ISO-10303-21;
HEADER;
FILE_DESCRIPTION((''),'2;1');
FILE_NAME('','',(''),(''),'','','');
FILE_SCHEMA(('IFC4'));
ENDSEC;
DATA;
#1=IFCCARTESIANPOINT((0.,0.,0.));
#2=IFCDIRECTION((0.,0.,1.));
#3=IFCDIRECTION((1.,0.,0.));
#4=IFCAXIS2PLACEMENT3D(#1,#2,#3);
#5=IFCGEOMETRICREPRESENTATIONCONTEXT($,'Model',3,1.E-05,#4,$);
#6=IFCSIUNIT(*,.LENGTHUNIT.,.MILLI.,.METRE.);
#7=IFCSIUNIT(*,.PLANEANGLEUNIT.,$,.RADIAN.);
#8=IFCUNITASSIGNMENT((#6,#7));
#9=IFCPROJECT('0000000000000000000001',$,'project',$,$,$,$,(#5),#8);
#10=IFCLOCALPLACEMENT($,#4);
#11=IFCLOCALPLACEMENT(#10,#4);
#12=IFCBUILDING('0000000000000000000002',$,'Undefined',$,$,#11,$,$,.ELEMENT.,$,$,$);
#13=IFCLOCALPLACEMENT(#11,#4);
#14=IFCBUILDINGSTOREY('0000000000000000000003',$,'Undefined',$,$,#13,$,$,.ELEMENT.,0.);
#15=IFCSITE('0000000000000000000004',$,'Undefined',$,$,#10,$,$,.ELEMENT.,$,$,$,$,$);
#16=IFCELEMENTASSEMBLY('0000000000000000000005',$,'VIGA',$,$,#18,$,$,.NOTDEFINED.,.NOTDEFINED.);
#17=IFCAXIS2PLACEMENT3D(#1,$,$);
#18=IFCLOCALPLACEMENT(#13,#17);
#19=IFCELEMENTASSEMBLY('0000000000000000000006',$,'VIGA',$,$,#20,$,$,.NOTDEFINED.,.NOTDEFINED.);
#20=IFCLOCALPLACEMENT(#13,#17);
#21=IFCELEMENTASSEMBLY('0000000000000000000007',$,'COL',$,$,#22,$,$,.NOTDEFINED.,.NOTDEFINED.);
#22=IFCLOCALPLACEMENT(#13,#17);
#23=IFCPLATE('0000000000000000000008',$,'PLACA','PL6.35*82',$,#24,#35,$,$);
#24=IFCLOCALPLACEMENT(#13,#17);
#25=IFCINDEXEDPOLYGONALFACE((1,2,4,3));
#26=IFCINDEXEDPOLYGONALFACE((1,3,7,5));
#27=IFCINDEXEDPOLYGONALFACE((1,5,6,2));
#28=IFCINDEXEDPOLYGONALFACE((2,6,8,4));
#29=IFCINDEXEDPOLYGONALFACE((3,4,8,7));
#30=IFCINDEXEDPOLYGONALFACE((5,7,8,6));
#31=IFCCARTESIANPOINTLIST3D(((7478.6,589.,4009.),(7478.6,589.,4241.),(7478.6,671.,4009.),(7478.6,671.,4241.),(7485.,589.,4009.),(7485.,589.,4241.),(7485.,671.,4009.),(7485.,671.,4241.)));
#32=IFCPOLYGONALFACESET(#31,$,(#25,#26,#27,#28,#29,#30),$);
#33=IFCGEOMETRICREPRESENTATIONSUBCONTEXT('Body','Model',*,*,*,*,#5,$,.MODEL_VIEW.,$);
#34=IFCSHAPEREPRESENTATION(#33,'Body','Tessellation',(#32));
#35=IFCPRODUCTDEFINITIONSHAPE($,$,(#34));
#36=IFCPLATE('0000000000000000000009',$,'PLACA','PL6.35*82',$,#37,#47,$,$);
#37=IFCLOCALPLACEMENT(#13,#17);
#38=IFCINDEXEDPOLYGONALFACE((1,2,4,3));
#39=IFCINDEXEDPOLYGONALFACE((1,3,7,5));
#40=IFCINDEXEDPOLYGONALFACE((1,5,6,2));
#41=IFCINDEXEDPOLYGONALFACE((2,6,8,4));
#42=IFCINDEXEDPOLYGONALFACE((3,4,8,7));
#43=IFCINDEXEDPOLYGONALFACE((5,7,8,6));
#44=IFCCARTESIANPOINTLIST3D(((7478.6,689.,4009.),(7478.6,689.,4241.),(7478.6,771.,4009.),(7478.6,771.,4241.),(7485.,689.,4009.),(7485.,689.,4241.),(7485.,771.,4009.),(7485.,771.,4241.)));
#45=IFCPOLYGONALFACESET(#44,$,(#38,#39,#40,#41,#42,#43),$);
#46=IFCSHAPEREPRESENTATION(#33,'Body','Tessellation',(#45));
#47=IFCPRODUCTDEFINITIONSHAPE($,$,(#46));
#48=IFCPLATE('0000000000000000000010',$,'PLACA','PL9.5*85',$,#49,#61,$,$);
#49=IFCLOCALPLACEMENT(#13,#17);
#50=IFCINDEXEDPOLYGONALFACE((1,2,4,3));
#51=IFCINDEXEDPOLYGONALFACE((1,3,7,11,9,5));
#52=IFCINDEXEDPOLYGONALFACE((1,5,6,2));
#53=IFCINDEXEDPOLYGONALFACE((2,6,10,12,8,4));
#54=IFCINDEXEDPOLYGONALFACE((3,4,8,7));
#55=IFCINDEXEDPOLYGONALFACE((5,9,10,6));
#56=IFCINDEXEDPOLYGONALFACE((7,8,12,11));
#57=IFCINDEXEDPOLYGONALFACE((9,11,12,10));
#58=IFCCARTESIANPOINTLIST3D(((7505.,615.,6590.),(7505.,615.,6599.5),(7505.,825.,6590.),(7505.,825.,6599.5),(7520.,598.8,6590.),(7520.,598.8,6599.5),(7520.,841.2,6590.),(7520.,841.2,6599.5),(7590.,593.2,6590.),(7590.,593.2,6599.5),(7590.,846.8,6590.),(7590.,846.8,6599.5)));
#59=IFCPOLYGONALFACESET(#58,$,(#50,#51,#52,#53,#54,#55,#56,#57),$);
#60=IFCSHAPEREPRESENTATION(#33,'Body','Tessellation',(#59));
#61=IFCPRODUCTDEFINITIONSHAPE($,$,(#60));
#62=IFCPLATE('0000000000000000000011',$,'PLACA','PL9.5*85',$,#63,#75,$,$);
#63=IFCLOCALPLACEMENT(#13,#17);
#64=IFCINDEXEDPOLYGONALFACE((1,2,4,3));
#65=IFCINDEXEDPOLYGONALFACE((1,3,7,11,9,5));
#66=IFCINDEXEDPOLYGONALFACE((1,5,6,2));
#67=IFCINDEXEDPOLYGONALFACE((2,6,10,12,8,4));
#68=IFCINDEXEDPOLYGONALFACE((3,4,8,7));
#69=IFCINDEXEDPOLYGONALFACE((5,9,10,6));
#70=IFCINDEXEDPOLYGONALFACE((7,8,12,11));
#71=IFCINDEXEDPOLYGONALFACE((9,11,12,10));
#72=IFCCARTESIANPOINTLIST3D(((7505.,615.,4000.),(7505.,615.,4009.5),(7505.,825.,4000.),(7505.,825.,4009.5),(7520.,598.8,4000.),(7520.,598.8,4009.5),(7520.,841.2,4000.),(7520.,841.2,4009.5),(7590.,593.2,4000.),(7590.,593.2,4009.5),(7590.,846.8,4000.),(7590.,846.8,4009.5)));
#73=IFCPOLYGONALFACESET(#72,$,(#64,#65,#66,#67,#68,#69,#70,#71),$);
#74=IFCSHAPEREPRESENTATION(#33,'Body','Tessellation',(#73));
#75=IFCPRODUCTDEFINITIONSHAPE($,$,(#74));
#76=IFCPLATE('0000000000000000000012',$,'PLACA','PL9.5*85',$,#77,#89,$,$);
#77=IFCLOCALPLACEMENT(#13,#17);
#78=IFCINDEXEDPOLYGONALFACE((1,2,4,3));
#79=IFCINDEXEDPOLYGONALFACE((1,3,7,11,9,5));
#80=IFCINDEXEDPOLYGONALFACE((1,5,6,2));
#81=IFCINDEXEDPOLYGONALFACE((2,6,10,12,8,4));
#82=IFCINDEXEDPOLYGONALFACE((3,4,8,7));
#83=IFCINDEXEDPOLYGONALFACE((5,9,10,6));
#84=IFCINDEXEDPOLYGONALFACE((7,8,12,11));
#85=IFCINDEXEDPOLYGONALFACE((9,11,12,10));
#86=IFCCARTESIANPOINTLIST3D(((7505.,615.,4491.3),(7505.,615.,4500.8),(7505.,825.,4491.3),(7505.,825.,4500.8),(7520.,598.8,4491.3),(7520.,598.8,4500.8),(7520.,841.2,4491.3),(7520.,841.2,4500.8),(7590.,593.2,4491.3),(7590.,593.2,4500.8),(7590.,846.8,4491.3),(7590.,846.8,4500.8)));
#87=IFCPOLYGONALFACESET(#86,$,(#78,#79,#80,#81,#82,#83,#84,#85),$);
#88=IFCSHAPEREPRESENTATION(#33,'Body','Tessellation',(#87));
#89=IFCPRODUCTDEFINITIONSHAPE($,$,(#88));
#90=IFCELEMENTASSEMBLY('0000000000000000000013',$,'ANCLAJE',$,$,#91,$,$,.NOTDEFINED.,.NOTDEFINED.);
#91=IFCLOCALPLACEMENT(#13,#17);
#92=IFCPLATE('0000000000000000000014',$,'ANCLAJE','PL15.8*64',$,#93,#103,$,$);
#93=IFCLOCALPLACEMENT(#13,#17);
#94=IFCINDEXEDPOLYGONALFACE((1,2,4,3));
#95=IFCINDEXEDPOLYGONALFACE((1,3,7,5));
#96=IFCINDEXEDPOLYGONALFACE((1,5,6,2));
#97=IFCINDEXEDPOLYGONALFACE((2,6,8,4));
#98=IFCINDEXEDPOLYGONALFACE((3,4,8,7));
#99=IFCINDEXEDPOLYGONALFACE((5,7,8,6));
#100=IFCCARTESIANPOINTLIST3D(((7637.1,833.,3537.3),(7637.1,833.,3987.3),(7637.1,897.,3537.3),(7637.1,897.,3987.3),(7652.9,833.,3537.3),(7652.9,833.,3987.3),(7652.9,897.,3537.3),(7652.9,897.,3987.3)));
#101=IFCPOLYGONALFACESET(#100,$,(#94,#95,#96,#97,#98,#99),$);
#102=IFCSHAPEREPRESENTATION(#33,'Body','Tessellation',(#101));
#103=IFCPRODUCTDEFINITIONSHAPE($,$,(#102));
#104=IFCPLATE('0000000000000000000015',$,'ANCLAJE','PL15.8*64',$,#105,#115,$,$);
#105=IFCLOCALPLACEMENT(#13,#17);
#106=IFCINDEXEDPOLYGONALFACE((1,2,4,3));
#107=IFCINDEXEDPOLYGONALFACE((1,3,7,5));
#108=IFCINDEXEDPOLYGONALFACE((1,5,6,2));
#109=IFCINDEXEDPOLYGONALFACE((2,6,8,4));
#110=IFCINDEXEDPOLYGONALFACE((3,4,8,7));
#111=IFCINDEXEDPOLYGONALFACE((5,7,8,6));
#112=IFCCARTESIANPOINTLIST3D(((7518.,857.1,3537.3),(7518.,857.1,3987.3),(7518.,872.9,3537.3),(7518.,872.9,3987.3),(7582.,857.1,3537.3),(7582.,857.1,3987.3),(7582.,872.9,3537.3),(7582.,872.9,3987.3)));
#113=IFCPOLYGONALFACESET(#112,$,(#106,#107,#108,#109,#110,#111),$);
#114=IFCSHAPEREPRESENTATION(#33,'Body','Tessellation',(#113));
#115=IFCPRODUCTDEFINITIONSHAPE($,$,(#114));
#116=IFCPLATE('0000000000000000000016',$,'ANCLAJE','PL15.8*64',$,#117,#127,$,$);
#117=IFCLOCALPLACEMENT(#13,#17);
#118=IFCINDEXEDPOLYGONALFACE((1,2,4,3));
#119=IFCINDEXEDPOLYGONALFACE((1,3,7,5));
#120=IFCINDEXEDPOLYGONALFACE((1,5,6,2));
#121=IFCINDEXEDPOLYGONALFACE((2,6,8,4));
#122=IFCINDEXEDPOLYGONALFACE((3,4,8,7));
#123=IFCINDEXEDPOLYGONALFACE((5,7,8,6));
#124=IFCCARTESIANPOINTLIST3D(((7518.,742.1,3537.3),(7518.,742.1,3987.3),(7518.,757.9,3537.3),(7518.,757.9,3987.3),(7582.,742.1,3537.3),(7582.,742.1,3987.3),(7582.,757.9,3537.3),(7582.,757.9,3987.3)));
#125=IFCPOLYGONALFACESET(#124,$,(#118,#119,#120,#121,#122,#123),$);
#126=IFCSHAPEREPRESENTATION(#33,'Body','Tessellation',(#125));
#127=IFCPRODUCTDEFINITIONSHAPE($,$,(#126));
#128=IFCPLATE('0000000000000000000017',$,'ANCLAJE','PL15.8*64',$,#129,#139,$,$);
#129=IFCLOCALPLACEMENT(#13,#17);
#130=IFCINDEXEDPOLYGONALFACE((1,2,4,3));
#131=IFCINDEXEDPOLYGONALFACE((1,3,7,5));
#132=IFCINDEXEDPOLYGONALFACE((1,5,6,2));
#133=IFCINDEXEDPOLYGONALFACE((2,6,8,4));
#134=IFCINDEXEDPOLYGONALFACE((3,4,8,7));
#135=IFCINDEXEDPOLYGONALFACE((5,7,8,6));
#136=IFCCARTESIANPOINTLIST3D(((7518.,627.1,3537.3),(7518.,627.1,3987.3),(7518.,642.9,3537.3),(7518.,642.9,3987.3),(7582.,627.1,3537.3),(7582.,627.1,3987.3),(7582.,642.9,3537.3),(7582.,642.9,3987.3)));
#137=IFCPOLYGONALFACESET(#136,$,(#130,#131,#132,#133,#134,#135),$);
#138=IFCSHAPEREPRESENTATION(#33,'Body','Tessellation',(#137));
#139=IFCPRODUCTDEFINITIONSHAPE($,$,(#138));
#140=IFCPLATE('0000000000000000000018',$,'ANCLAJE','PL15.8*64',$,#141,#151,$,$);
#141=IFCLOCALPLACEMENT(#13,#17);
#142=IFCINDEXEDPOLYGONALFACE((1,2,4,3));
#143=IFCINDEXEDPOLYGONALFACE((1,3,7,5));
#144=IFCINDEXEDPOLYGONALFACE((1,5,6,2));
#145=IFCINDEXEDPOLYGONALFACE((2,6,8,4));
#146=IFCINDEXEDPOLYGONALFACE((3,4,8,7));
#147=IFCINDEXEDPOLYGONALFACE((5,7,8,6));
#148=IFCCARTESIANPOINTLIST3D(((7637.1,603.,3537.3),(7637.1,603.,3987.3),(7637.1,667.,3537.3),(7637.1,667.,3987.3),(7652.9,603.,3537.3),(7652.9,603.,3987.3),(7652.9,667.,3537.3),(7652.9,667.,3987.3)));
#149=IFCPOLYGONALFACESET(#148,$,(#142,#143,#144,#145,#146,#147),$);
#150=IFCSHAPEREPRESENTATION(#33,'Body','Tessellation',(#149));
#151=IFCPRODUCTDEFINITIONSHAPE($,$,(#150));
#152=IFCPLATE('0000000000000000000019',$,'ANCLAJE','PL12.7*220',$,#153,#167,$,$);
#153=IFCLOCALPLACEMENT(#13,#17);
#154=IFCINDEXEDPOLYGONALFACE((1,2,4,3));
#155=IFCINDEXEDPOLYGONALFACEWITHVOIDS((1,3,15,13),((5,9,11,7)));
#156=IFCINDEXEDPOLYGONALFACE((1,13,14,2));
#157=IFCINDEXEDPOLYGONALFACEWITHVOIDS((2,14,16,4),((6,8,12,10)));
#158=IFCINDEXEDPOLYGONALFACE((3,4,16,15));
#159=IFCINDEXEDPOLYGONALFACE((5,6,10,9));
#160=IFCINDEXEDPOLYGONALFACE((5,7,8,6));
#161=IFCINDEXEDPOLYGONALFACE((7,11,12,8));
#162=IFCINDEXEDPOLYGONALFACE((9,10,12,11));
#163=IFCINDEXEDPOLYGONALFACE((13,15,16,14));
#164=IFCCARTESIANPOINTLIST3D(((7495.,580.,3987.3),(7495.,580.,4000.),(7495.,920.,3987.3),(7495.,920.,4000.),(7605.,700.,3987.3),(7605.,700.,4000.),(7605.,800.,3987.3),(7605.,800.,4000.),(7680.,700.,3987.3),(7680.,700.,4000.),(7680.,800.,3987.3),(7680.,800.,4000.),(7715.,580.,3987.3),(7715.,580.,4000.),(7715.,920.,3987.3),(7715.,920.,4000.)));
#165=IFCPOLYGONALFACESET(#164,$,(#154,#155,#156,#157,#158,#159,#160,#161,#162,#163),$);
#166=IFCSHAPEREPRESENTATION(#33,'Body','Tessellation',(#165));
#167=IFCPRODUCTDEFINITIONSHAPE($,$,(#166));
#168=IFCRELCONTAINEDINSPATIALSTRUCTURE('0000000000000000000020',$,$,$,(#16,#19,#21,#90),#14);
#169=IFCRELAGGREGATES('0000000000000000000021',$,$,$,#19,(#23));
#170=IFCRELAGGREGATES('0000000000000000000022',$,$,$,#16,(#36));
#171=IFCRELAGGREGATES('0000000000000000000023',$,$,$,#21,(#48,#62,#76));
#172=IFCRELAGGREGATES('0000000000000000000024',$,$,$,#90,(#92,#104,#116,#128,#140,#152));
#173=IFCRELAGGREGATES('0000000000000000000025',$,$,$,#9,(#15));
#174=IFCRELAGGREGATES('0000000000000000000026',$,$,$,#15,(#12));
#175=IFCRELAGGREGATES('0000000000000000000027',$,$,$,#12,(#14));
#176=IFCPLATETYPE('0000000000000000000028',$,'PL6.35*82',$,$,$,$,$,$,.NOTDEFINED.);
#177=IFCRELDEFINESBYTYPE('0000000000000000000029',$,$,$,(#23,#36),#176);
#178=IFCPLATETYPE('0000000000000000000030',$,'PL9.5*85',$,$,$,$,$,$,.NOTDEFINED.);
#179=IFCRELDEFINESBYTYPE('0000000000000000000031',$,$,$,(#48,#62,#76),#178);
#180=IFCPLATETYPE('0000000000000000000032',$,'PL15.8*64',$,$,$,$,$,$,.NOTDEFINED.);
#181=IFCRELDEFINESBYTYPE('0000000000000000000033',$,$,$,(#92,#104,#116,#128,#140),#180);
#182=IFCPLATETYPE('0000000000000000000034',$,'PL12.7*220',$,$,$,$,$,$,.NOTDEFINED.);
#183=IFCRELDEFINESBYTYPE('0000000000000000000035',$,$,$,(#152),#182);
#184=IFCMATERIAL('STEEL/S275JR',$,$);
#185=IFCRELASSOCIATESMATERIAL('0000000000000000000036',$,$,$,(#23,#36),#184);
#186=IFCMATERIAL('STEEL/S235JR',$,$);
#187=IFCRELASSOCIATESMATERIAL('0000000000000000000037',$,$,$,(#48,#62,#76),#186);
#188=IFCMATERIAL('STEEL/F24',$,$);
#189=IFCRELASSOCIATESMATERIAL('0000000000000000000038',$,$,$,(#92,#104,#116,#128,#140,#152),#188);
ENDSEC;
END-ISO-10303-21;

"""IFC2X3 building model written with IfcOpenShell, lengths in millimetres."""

from ifc_helpers import new_model, si_unit, frame, origin_with_axes, place, context, subcontext, project, spatial, polyline, outline, extrude, boolean, material, type_object, element, aggregate, save


model = new_model("IFC2X3")

# Units and contexts
model_context = context("Model", 3, precision=1e-05, world=origin_with_axes())
body_context = subcontext(model_context, "Body", "Model", "MODEL_VIEW")
ifc_project = project(units=[si_unit("LENGTHUNIT", "METRE", prefix="MILLI"), si_unit("PLANEANGLEUNIT", "RADIAN")], contexts=[model_context])

# Site, building, storey
site_placement = place(None, origin_with_axes())
site = spatial("IfcSite", under=ifc_project, at=site_placement, Name="Undefined", CompositionType="ELEMENT")
building_placement = place(site_placement, origin_with_axes())
building = spatial("IfcBuilding", under=site, at=building_placement, Name="Undefined", CompositionType="ELEMENT")
storey_placement = place(building_placement, origin_with_axes())
storey = spatial("IfcBuildingStorey", under=building, at=storey_placement, Name="Undefined", CompositionType="ELEMENT", Elevation=0.0)

# Shared definitions
ifc_material_1 = material(Name="STEEL/S275JR")

# Element assemblies
ifc_material_2 = material(Name="STEEL/S235JR")
assembly_1_placement = place(storey_placement, origin_with_axes())
assembly_1 = element("IfcElementAssembly", 1, at=assembly_1_placement, inside=storey, Name="VIGA", AssemblyPlace="NOTDEFINED", PredefinedType="NOTDEFINED")
assembly_2_placement = place(storey_placement, origin_with_axes())
assembly_2 = element("IfcElementAssembly", 2, at=assembly_2_placement, inside=storey, Name="VIGA", AssemblyPlace="NOTDEFINED", PredefinedType="NOTDEFINED")

# Element assembly
assembly_3_placement = place(storey_placement, origin_with_axes())
assembly_3 = element("IfcElementAssembly", 3, at=assembly_3_placement, inside=storey, Name="COL", AssemblyPlace="NOTDEFINED", PredefinedType="NOTDEFINED")

# Plates
plate_type_1 = type_object("IfcPlateType", Name="PL6.35*82", PredefinedType="NOTDEFINED")
plate_1_placement = place(assembly_2_placement, frame((7481.8, 589.0, 4241.0), z_axis=(-1.0, 0.0, 0.0), x_axis=(0.0, 1.0, 0.0)))
plate_1 = element("IfcPlate", 4, at=plate_1_placement, type_object=plate_type_1, material=ifc_material_1, Name="PLACA", Description="PL6.35*82", context=body_context, shape_type="SweptSolid", body=[
    extrude(outline(polyline([(0.0, 0.0), (82.0, 0.0), (82.0, 232.0), (0.0, 232.0), (0.0, 0.0)])), frame((0.0, 0.0, -3.2), z_axis=(0.0, 0.0, 1.0), x_axis=(1.0, 0.0, 0.0)), (0.0, 0.0, 1.0), 6.4),
])
aggregate(assembly_2, [plate_1])
plate_2_placement = place(assembly_1_placement, frame((7481.8, 689.0, 4241.0), z_axis=(-1.0, 0.0, 0.0), x_axis=(0.0, 1.0, 0.0)))
plate_2 = element("IfcPlate", 5, at=plate_2_placement, type_object=plate_type_1, material=ifc_material_1, Name="PLACA", Description="PL6.35*82", context=body_context, shape_type="SweptSolid", body=[
    extrude(outline(polyline([(0.0, 0.0), (82.0, 0.0), (82.0, 232.0), (0.0, 232.0), (0.0, 0.0)])), frame((0.0, 0.0, -3.2), z_axis=(0.0, 0.0, 1.0), x_axis=(1.0, 0.0, 0.0)), (0.0, 0.0, 1.0), 6.4),
])
aggregate(assembly_1, [plate_2])
plate_type_2 = type_object("IfcPlateType", Name="PL9.5*85", PredefinedType="NOTDEFINED")
plate_3_placement = place(assembly_3_placement, frame((7590.0, 846.8, 6594.8), z_axis=(0.0, 0.0, 1.0), x_axis=(-0.996815, -0.079745, 0.0)))
plate_3 = element("IfcPlate", 6, at=plate_3_placement, type_object=plate_type_2, material=ifc_material_2, Name="PLACA", Description="PL9.5*85", context=body_context, shape_type="SweptSolid", body=[
    extrude(outline(polyline([(0.0, 0.0), (70.3, 0.0), (86.5, 15.0), (103.2, 224.3), (89.6, 241.6), (20.2, 252.8), (0.0, 0.0)])), frame((0.0, 0.0, -4.7), z_axis=(0.0, 0.0, 1.0), x_axis=(1.0, 0.0, 0.0)), (0.0, 0.0, 1.0), 9.5),
])
plate_4_placement = place(assembly_3_placement, frame((7590.0, 846.8, 4004.8), z_axis=(0.0, 0.0, 1.0), x_axis=(-0.996815, -0.079745, 0.0)))
plate_4 = element("IfcPlate", 7, at=plate_4_placement, type_object=plate_type_2, material=ifc_material_2, Name="PLACA", Description="PL9.5*85", context=body_context, shape_type="SweptSolid", body=[
    extrude(outline(polyline([(0.0, 0.0), (70.3, 0.0), (86.5, 15.0), (103.2, 224.3), (89.6, 241.6), (20.2, 252.8), (0.0, 0.0)])), frame((0.0, 0.0, -4.7), z_axis=(0.0, 0.0, 1.0), x_axis=(1.0, 0.0, 0.0)), (0.0, 0.0, 1.0), 9.5),
])
plate_5_placement = place(assembly_3_placement, frame((7590.0, 846.8, 4496.0), z_axis=(0.0, 0.0, 1.0), x_axis=(-0.996815, -0.079745, 0.0)))
plate_5 = element("IfcPlate", 8, at=plate_5_placement, type_object=plate_type_2, material=ifc_material_2, Name="PLACA", Description="PL9.5*85", context=body_context, shape_type="SweptSolid", body=[
    extrude(outline(polyline([(0.0, 0.0), (70.3, 0.0), (86.5, 15.0), (103.2, 224.3), (89.6, 241.6), (20.2, 252.8), (0.0, 0.0)])), frame((0.0, 0.0, -4.7), z_axis=(0.0, 0.0, 1.0), x_axis=(1.0, 0.0, 0.0)), (0.0, 0.0, 1.0), 9.5),
])
aggregate(assembly_3, [plate_3, plate_4, plate_5])

# Element assembly, plates
assembly_4_placement = place(storey_placement, origin_with_axes())
assembly_4 = element("IfcElementAssembly", 9, at=assembly_4_placement, inside=storey, Name="ANCLAJE", AssemblyPlace="NOTDEFINED", PredefinedType="NOTDEFINED")
ifc_material_3 = material(Name="STEEL/F24")
plate_type_3 = type_object("IfcPlateType", Name="PL15.8*64", PredefinedType="NOTDEFINED")
plate_6_placement = place(assembly_4_placement, frame((7645.0, 897.0, 3987.3), z_axis=(1.0, 0.0, 0.0), x_axis=(0.0, -1.0, 0.0)))
plate_6 = element("IfcPlate", 10, at=plate_6_placement, type_object=plate_type_3, material=ifc_material_3, Name="ANCLAJE", Description="PL15.8*64", context=body_context, shape_type="SweptSolid", body=[
    extrude(outline(polyline([(0.0, 0.0), (64.0, 0.0), (64.0, 450.0), (0.0, 450.0), (0.0, 0.0)])), frame((0.0, 0.0, -7.9), z_axis=(0.0, 0.0, 1.0), x_axis=(1.0, 0.0, 0.0)), (0.0, 0.0, 1.0), 15.8),
])
plate_7_placement = place(assembly_4_placement, frame((7582.0, 865.0, 3987.3), z_axis=(0.0, -1.0, 0.0), x_axis=(-1.0, 0.0, 0.0)))
plate_7 = element("IfcPlate", 11, at=plate_7_placement, type_object=plate_type_3, material=ifc_material_3, Name="ANCLAJE", Description="PL15.8*64", context=body_context, shape_type="SweptSolid", body=[
    extrude(outline(polyline([(0.0, 0.0), (64.0, 0.0), (64.0, 450.0), (0.0, 450.0), (0.0, 0.0)])), frame((0.0, 0.0, -7.9), z_axis=(0.0, 0.0, 1.0), x_axis=(1.0, 0.0, 0.0)), (0.0, 0.0, 1.0), 15.8),
])
plate_8_placement = place(assembly_4_placement, frame((7582.0, 750.0, 3987.3), z_axis=(0.0, -1.0, 0.0), x_axis=(-1.0, 0.0, 0.0)))
plate_8 = element("IfcPlate", 12, at=plate_8_placement, type_object=plate_type_3, material=ifc_material_3, Name="ANCLAJE", Description="PL15.8*64", context=body_context, shape_type="SweptSolid", body=[
    extrude(outline(polyline([(0.0, 0.0), (64.0, 0.0), (64.0, 450.0), (0.0, 450.0), (0.0, 0.0)])), frame((0.0, 0.0, -7.9), z_axis=(0.0, 0.0, 1.0), x_axis=(1.0, 0.0, 0.0)), (0.0, 0.0, 1.0), 15.8),
])
plate_9_placement = place(assembly_4_placement, frame((7582.0, 635.0, 3987.3), z_axis=(0.0, -1.0, 0.0), x_axis=(-1.0, 0.0, 0.0)))
plate_9 = element("IfcPlate", 13, at=plate_9_placement, type_object=plate_type_3, material=ifc_material_3, Name="ANCLAJE", Description="PL15.8*64", context=body_context, shape_type="SweptSolid", body=[
    extrude(outline(polyline([(0.0, 0.0), (64.0, 0.0), (64.0, 450.0), (0.0, 450.0), (0.0, 0.0)])), frame((0.0, 0.0, -7.9), z_axis=(0.0, 0.0, 1.0), x_axis=(1.0, 0.0, 0.0)), (0.0, 0.0, 1.0), 15.8),
])
plate_10_placement = place(assembly_4_placement, frame((7645.0, 603.0, 3987.3), z_axis=(-1.0, 0.0, 0.0), x_axis=(0.0, 1.0, 0.0)))
plate_10 = element("IfcPlate", 14, at=plate_10_placement, type_object=plate_type_3, material=ifc_material_3, Name="ANCLAJE", Description="PL15.8*64", context=body_context, shape_type="SweptSolid", body=[
    extrude(outline(polyline([(0.0, 0.0), (64.0, 0.0), (64.0, 450.0), (0.0, 450.0), (0.0, 0.0)])), frame((0.0, 0.0, -7.9), z_axis=(0.0, 0.0, 1.0), x_axis=(1.0, 0.0, 0.0)), (0.0, 0.0, 1.0), 15.8),
])
plate_type_4 = type_object("IfcPlateType", Name="PL12.7*220", PredefinedType="NOTDEFINED")
plate_11_placement = place(assembly_4_placement, frame((7495.0, 580.0, 3993.7), z_axis=(0.0, 0.0, 1.0), x_axis=(1.0, 0.0, 0.0)))
plate_11 = element("IfcPlate", 15, at=plate_11_placement, type_object=plate_type_4, material=ifc_material_3, Name="ANCLAJE", Description="PL12.7*220", context=body_context, shape_type="CSG", body=[
    boolean("DIFFERENCE", extrude(outline(polyline([(0.0, 0.0), (220.0, 0.0), (220.0, 340.0), (0.0, 340.0), (0.0, 0.0)])), frame((0.0, 0.0, -6.3), z_axis=(0.0, 0.0, 1.0), x_axis=(1.0, 0.0, 0.0)), (0.0, 0.0, 1.0), 12.7), extrude(outline(polyline([(0.0, 0.0), (75.0, 0.0), (75.0, 100.0), (0.0, 100.0), (0.0, 0.0)])), frame((185.0, 220.0, -7.9), z_axis=(0.0, 0.0, 1.0), x_axis=(-1.0, 0.0, 0.0)), (0.0, 0.0, 1.0), 15.8)),
])
aggregate(assembly_4, [plate_6, plate_7, plate_8, plate_9, plate_10, plate_11])

save(model, "model.ifc")
